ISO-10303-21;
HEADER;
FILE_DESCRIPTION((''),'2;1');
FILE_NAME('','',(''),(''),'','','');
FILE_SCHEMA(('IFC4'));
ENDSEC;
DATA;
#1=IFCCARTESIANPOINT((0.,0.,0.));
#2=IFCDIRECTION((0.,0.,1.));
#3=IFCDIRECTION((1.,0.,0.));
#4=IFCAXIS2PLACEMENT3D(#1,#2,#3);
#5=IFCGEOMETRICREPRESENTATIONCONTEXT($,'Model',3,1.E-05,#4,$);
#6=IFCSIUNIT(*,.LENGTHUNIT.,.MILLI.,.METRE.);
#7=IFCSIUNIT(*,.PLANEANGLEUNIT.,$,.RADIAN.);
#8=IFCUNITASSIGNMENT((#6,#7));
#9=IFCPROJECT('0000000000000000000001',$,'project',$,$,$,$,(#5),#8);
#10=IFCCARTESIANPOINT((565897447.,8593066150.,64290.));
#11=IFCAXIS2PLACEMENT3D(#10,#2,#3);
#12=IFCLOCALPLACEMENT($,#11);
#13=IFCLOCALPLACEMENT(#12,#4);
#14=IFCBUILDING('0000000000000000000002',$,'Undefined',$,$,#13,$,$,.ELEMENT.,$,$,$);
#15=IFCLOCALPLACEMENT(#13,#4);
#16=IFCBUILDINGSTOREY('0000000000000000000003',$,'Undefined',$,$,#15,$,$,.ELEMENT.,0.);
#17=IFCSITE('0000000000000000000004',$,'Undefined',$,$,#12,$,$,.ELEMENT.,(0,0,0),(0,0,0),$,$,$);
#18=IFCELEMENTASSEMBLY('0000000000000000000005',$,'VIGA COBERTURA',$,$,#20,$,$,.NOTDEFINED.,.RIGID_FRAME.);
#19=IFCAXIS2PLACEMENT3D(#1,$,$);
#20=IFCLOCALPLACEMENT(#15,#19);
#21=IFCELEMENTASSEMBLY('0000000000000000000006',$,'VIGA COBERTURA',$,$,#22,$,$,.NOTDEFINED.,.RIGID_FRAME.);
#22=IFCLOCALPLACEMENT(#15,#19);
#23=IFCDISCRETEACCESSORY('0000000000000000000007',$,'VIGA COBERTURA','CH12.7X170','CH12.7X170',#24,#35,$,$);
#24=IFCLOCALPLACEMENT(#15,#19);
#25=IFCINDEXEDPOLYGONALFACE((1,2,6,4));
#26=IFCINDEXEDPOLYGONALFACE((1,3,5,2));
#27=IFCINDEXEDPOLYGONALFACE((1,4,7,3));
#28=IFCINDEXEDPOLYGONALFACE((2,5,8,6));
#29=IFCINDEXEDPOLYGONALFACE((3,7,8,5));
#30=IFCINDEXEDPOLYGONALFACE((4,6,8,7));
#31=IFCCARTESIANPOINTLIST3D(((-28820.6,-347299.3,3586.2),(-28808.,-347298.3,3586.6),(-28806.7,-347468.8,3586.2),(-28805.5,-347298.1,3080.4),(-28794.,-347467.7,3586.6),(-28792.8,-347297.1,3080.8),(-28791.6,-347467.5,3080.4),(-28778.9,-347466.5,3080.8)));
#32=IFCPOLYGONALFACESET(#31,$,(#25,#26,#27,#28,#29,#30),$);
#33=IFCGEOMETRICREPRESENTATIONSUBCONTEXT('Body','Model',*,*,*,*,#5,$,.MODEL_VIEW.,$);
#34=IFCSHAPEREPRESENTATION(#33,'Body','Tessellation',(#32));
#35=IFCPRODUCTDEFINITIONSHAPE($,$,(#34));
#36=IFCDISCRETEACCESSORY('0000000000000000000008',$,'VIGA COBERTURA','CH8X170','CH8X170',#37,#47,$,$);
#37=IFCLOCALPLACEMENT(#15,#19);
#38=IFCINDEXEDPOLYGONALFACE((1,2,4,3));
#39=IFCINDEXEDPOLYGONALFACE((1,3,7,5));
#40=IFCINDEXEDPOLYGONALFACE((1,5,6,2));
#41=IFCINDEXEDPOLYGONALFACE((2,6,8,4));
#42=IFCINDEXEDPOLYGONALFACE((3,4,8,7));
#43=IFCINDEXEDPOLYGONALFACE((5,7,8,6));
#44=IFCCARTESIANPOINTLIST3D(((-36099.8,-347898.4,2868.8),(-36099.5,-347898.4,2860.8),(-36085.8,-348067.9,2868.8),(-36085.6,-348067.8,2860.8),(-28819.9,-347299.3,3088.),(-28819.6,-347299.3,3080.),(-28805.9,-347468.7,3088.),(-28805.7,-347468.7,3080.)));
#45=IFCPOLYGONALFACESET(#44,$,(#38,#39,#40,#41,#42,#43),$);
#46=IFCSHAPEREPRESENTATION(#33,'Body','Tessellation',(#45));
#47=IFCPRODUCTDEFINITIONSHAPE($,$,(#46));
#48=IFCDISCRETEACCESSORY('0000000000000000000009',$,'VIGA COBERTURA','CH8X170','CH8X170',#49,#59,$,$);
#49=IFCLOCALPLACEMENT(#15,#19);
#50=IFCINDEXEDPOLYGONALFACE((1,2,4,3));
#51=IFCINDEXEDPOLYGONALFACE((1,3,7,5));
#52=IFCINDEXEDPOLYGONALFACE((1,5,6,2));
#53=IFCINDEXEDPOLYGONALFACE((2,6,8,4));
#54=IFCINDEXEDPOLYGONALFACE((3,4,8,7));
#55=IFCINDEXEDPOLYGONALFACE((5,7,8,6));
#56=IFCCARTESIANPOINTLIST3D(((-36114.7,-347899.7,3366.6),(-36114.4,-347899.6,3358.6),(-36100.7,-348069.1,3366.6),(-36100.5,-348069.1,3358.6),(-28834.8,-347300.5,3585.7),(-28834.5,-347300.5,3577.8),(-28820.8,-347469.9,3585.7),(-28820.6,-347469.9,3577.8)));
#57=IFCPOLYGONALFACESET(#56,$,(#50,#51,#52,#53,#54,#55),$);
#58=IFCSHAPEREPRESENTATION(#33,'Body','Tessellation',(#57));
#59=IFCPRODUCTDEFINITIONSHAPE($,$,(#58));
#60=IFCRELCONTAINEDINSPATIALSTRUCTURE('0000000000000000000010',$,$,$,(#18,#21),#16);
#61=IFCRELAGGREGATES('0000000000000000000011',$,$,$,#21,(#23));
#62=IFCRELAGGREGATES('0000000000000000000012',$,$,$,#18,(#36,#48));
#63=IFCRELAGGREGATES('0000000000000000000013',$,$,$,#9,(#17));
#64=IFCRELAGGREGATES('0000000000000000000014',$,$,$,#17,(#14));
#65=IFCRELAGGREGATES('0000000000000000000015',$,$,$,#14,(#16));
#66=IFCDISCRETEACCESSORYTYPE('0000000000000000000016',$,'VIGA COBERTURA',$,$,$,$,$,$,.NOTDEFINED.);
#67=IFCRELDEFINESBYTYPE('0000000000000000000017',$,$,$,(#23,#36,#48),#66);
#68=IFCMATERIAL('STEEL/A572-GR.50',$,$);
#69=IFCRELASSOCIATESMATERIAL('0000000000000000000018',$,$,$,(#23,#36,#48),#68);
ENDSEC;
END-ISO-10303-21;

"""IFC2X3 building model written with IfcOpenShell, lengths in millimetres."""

from ifc_helpers import new_model, si_unit, frame, origin_with_axes, origin_2d_with_axis, place, context, subcontext, project, spatial, polyline, rectangle, outline, extrude, material, type_object, element, aggregate, save


model = new_model("IFC2X3")

# Units and contexts
model_context = context("Model", 3, precision=1e-05, world=origin_with_axes())
body_context = subcontext(model_context, "Body", "Model", "MODEL_VIEW")
ifc_project = project(units=[si_unit("LENGTHUNIT", "METRE", prefix="MILLI"), si_unit("PLANEANGLEUNIT", "RADIAN")], contexts=[model_context])

# Site, building, storey
site_placement = place(None, frame((565897447.0, 8593066150.0, 64290.0), z_axis=(0.0, 0.0, 1.0), x_axis=(1.0, 0.0, 0.0)))
site = spatial("IfcSite", under=ifc_project, at=site_placement, Name="Undefined", CompositionType="ELEMENT", RefLatitude=(0, 0, 0), RefLongitude=(0, 0, 0))
building_placement = place(site_placement, origin_with_axes())
building = spatial("IfcBuilding", under=site, at=building_placement, Name="Undefined", CompositionType="ELEMENT")
storey_placement = place(building_placement, origin_with_axes())
storey = spatial("IfcBuildingStorey", under=building, at=storey_placement, Name="Undefined", CompositionType="ELEMENT", Elevation=0.0)

# Shared definitions
ifc_material_1 = material(Name="STEEL/A572-GR.50")
discrete_accessory_type_1 = type_object("IfcDiscreteAccessoryType", Name="VIGA COBERTURA")

# Element assemblies, discrete accessory
assembly_1_placement = place(storey_placement, origin_with_axes())
assembly_1 = element("IfcElementAssembly", 1, at=assembly_1_placement, inside=storey, Name="VIGA COBERTURA", AssemblyPlace="NOTDEFINED", PredefinedType="RIGID_FRAME")
assembly_2_placement = place(storey_placement, origin_with_axes())
assembly_2 = element("IfcElementAssembly", 2, at=assembly_2_placement, inside=storey, Name="VIGA COBERTURA", AssemblyPlace="NOTDEFINED", PredefinedType="RIGID_FRAME")
discrete_accessory_1_placement = place(assembly_2_placement, frame((-28807.3, -347383.5, 3586.4), z_axis=(0.082025, -0.99663, 0.0), x_axis=(0.029885, 0.00246, -0.99955)))
discrete_accessory_1 = element("IfcDiscreteAccessory", 3, at=discrete_accessory_1_placement, type_object=discrete_accessory_type_1, material=ifc_material_1, Name="VIGA COBERTURA", Description="CH12.7X170", ObjectType="CH12.7X170", context=body_context, shape_type="SweptSolid", body=[
    extrude(rectangle(XDim=12.7, YDim=170.0, at=origin_2d_with_axis()), frame((506.0, 0.0, 0.0), z_axis=(-1.0, 0.0, 0.0), x_axis=(0.0, -1.0, 0.0)), (0.0, 0.0, 1.0), 506.0),
])

# Discrete accessories
discrete_accessory_2_placement = place(assembly_1_placement, frame((-28812.8, -347384.0, 3084.0), z_axis=(0.029885, 0.00246, -0.99955), x_axis=(-0.996182, -0.081989, -0.029987)))
discrete_accessory_2 = element("IfcDiscreteAccessory", 4, at=discrete_accessory_2_placement, type_object=discrete_accessory_type_1, material=ifc_material_1, Name="VIGA COBERTURA", Description="CH8X170", ObjectType="CH8X170", context=body_context, shape_type="SweptSolid", body=[
    extrude(outline(polyline([(7307.8, 85.0), (7307.8, -85.0), (0.0, -85.0), (0.0, 85.0), (7307.8, 85.0)])), frame((0.0, 0.0, -4.0), z_axis=(0.0, 0.0, 1.0), x_axis=(1.0, 0.0, 0.0)), (0.0, 0.0, 1.0), 8.0),
])
aggregate(assembly_2, [discrete_accessory_1])
discrete_accessory_3_placement = place(assembly_1_placement, frame((-28827.7, -347385.2, 3581.7), z_axis=(0.029885, 0.00246, -0.99955), x_axis=(-0.996182, -0.081989, -0.029987)))
discrete_accessory_3 = element("IfcDiscreteAccessory", 5, at=discrete_accessory_3_placement, type_object=discrete_accessory_type_1, material=ifc_material_1, Name="VIGA COBERTURA", Description="CH8X170", ObjectType="CH8X170", context=body_context, shape_type="SweptSolid", body=[
    extrude(outline(polyline([(7307.8, 85.0), (7307.8, -85.0), (0.0, -85.0), (0.0, 85.0), (7307.8, 85.0)])), frame((0.0, 0.0, -4.0), z_axis=(0.0, 0.0, 1.0), x_axis=(1.0, 0.0, 0.0)), (0.0, 0.0, 1.0), 8.0),
])
aggregate(assembly_1, [discrete_accessory_2, discrete_accessory_3])

save(model, "model.ifc")
